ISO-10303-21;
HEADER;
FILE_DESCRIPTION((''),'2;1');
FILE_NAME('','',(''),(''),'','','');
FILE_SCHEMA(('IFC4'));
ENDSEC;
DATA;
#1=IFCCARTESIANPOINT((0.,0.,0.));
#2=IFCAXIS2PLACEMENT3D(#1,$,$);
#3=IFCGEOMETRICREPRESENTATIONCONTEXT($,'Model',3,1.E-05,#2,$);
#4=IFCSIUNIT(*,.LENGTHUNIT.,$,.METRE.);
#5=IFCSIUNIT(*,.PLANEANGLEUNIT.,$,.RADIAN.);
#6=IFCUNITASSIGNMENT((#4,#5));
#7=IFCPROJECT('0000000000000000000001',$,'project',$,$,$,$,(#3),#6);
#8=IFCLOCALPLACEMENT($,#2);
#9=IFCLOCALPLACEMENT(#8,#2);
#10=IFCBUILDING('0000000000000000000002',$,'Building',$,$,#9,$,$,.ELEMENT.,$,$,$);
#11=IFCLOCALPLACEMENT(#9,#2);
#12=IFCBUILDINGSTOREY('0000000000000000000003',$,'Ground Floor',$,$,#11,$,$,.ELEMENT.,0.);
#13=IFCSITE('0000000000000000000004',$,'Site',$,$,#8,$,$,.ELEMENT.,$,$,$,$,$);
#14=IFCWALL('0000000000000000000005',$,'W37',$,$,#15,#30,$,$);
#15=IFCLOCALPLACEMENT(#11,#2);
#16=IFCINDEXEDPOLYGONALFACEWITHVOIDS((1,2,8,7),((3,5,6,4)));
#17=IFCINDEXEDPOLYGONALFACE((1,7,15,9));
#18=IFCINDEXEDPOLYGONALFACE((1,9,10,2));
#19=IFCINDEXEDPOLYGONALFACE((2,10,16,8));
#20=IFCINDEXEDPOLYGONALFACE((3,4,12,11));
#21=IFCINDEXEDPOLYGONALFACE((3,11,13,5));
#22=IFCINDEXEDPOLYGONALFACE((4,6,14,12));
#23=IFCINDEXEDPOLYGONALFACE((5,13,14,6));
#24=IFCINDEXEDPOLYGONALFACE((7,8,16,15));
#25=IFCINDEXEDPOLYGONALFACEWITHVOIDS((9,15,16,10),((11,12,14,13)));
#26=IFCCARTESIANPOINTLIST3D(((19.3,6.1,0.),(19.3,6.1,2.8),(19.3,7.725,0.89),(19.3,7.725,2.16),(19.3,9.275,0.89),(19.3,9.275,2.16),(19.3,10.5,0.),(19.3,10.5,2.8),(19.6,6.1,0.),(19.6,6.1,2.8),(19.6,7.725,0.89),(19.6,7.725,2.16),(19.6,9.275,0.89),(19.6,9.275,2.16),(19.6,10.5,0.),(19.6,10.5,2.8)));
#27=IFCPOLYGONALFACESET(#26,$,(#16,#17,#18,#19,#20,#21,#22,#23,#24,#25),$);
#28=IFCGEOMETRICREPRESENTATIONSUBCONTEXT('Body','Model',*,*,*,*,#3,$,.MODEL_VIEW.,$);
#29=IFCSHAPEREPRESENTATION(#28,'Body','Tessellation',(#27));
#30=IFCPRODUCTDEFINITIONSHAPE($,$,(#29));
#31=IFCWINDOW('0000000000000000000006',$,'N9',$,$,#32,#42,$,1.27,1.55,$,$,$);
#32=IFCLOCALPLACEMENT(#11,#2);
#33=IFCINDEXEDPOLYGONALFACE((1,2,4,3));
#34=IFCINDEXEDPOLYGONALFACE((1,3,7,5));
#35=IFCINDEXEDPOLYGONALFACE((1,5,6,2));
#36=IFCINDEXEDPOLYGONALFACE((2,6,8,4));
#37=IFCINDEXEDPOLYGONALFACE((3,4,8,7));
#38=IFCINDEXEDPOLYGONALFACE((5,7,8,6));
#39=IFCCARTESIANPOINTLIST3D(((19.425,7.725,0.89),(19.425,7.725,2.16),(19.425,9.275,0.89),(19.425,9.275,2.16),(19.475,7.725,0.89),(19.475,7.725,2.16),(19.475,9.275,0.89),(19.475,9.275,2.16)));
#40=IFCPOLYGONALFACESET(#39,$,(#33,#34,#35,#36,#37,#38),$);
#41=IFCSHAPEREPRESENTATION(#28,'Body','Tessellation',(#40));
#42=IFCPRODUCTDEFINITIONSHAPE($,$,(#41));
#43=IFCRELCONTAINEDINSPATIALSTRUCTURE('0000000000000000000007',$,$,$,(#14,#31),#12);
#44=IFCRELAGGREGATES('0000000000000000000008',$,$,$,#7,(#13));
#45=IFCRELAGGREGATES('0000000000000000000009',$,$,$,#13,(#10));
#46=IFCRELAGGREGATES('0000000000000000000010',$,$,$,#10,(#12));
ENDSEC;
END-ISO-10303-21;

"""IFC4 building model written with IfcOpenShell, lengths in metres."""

from ifc_helpers import new_model, si_unit, frame, frame_2d, origin, origin_2d, place, context, subcontext, project, spatial, rectangle, extrude, element, fill, save


model = new_model("IFC4")

# Units and contexts
model_context = context("Model", 3, precision=1e-05, world=origin())
body_context = subcontext(model_context, "Body", "Model", "MODEL_VIEW")
ifc_project = project(units=[si_unit("LENGTHUNIT", "METRE"), si_unit("PLANEANGLEUNIT", "RADIAN")], contexts=[model_context])

# Site, building, storey
site_placement = place(None, origin())
site = spatial("IfcSite", under=ifc_project, at=site_placement, Name="Site", CompositionType="ELEMENT")
building_placement = place(site_placement, origin())
building = spatial("IfcBuilding", under=site, at=building_placement, Name="Building", CompositionType="ELEMENT")
storey_placement = place(building_placement, origin())
storey = spatial("IfcBuildingStorey", under=building, at=storey_placement, Name="Ground Floor", CompositionType="ELEMENT", Elevation=0.0)

# Wall, opening, window
wall_1_placement = place(storey_placement, frame((19.45, 6.25, 0.0), x_axis=(0.0, 1.0, 0.0)))
wall_1 = element("IfcWall", 1, at=wall_1_placement, inside=storey, Name="W37", context=body_context, shape_type="SweptSolid", body=[
    extrude(rectangle(XDim=4.4, YDim=0.3, at=frame_2d((2.05, 0.0))), origin(), (0.0, 0.0, 1.0), 2.8),
])
opening_1_placement = place(wall_1_placement, frame((2.25, 0.0, 0.89)))
opening_1 = element("IfcOpeningElement", 2, at=opening_1_placement, cuts=wall_1, context=body_context, shape_type="SweptSolid", body=[
    extrude(rectangle(XDim=1.55, YDim=0.4, at=origin_2d()), origin(), (0.0, 0.0, 1.0), 1.27),
])
window_1_placement = place(opening_1_placement, origin())
window_1 = element("IfcWindow", 3, at=window_1_placement, inside=storey, Name="N9", OverallHeight=1.27, OverallWidth=1.55, context=body_context, shape_type="SweptSolid", body=[
    extrude(rectangle(XDim=1.55, YDim=0.05, at=origin_2d()), origin(), (0.0, 0.0, 1.0), 1.27),
])
fill(opening_1, window_1)

save(model, "model.ifc")
